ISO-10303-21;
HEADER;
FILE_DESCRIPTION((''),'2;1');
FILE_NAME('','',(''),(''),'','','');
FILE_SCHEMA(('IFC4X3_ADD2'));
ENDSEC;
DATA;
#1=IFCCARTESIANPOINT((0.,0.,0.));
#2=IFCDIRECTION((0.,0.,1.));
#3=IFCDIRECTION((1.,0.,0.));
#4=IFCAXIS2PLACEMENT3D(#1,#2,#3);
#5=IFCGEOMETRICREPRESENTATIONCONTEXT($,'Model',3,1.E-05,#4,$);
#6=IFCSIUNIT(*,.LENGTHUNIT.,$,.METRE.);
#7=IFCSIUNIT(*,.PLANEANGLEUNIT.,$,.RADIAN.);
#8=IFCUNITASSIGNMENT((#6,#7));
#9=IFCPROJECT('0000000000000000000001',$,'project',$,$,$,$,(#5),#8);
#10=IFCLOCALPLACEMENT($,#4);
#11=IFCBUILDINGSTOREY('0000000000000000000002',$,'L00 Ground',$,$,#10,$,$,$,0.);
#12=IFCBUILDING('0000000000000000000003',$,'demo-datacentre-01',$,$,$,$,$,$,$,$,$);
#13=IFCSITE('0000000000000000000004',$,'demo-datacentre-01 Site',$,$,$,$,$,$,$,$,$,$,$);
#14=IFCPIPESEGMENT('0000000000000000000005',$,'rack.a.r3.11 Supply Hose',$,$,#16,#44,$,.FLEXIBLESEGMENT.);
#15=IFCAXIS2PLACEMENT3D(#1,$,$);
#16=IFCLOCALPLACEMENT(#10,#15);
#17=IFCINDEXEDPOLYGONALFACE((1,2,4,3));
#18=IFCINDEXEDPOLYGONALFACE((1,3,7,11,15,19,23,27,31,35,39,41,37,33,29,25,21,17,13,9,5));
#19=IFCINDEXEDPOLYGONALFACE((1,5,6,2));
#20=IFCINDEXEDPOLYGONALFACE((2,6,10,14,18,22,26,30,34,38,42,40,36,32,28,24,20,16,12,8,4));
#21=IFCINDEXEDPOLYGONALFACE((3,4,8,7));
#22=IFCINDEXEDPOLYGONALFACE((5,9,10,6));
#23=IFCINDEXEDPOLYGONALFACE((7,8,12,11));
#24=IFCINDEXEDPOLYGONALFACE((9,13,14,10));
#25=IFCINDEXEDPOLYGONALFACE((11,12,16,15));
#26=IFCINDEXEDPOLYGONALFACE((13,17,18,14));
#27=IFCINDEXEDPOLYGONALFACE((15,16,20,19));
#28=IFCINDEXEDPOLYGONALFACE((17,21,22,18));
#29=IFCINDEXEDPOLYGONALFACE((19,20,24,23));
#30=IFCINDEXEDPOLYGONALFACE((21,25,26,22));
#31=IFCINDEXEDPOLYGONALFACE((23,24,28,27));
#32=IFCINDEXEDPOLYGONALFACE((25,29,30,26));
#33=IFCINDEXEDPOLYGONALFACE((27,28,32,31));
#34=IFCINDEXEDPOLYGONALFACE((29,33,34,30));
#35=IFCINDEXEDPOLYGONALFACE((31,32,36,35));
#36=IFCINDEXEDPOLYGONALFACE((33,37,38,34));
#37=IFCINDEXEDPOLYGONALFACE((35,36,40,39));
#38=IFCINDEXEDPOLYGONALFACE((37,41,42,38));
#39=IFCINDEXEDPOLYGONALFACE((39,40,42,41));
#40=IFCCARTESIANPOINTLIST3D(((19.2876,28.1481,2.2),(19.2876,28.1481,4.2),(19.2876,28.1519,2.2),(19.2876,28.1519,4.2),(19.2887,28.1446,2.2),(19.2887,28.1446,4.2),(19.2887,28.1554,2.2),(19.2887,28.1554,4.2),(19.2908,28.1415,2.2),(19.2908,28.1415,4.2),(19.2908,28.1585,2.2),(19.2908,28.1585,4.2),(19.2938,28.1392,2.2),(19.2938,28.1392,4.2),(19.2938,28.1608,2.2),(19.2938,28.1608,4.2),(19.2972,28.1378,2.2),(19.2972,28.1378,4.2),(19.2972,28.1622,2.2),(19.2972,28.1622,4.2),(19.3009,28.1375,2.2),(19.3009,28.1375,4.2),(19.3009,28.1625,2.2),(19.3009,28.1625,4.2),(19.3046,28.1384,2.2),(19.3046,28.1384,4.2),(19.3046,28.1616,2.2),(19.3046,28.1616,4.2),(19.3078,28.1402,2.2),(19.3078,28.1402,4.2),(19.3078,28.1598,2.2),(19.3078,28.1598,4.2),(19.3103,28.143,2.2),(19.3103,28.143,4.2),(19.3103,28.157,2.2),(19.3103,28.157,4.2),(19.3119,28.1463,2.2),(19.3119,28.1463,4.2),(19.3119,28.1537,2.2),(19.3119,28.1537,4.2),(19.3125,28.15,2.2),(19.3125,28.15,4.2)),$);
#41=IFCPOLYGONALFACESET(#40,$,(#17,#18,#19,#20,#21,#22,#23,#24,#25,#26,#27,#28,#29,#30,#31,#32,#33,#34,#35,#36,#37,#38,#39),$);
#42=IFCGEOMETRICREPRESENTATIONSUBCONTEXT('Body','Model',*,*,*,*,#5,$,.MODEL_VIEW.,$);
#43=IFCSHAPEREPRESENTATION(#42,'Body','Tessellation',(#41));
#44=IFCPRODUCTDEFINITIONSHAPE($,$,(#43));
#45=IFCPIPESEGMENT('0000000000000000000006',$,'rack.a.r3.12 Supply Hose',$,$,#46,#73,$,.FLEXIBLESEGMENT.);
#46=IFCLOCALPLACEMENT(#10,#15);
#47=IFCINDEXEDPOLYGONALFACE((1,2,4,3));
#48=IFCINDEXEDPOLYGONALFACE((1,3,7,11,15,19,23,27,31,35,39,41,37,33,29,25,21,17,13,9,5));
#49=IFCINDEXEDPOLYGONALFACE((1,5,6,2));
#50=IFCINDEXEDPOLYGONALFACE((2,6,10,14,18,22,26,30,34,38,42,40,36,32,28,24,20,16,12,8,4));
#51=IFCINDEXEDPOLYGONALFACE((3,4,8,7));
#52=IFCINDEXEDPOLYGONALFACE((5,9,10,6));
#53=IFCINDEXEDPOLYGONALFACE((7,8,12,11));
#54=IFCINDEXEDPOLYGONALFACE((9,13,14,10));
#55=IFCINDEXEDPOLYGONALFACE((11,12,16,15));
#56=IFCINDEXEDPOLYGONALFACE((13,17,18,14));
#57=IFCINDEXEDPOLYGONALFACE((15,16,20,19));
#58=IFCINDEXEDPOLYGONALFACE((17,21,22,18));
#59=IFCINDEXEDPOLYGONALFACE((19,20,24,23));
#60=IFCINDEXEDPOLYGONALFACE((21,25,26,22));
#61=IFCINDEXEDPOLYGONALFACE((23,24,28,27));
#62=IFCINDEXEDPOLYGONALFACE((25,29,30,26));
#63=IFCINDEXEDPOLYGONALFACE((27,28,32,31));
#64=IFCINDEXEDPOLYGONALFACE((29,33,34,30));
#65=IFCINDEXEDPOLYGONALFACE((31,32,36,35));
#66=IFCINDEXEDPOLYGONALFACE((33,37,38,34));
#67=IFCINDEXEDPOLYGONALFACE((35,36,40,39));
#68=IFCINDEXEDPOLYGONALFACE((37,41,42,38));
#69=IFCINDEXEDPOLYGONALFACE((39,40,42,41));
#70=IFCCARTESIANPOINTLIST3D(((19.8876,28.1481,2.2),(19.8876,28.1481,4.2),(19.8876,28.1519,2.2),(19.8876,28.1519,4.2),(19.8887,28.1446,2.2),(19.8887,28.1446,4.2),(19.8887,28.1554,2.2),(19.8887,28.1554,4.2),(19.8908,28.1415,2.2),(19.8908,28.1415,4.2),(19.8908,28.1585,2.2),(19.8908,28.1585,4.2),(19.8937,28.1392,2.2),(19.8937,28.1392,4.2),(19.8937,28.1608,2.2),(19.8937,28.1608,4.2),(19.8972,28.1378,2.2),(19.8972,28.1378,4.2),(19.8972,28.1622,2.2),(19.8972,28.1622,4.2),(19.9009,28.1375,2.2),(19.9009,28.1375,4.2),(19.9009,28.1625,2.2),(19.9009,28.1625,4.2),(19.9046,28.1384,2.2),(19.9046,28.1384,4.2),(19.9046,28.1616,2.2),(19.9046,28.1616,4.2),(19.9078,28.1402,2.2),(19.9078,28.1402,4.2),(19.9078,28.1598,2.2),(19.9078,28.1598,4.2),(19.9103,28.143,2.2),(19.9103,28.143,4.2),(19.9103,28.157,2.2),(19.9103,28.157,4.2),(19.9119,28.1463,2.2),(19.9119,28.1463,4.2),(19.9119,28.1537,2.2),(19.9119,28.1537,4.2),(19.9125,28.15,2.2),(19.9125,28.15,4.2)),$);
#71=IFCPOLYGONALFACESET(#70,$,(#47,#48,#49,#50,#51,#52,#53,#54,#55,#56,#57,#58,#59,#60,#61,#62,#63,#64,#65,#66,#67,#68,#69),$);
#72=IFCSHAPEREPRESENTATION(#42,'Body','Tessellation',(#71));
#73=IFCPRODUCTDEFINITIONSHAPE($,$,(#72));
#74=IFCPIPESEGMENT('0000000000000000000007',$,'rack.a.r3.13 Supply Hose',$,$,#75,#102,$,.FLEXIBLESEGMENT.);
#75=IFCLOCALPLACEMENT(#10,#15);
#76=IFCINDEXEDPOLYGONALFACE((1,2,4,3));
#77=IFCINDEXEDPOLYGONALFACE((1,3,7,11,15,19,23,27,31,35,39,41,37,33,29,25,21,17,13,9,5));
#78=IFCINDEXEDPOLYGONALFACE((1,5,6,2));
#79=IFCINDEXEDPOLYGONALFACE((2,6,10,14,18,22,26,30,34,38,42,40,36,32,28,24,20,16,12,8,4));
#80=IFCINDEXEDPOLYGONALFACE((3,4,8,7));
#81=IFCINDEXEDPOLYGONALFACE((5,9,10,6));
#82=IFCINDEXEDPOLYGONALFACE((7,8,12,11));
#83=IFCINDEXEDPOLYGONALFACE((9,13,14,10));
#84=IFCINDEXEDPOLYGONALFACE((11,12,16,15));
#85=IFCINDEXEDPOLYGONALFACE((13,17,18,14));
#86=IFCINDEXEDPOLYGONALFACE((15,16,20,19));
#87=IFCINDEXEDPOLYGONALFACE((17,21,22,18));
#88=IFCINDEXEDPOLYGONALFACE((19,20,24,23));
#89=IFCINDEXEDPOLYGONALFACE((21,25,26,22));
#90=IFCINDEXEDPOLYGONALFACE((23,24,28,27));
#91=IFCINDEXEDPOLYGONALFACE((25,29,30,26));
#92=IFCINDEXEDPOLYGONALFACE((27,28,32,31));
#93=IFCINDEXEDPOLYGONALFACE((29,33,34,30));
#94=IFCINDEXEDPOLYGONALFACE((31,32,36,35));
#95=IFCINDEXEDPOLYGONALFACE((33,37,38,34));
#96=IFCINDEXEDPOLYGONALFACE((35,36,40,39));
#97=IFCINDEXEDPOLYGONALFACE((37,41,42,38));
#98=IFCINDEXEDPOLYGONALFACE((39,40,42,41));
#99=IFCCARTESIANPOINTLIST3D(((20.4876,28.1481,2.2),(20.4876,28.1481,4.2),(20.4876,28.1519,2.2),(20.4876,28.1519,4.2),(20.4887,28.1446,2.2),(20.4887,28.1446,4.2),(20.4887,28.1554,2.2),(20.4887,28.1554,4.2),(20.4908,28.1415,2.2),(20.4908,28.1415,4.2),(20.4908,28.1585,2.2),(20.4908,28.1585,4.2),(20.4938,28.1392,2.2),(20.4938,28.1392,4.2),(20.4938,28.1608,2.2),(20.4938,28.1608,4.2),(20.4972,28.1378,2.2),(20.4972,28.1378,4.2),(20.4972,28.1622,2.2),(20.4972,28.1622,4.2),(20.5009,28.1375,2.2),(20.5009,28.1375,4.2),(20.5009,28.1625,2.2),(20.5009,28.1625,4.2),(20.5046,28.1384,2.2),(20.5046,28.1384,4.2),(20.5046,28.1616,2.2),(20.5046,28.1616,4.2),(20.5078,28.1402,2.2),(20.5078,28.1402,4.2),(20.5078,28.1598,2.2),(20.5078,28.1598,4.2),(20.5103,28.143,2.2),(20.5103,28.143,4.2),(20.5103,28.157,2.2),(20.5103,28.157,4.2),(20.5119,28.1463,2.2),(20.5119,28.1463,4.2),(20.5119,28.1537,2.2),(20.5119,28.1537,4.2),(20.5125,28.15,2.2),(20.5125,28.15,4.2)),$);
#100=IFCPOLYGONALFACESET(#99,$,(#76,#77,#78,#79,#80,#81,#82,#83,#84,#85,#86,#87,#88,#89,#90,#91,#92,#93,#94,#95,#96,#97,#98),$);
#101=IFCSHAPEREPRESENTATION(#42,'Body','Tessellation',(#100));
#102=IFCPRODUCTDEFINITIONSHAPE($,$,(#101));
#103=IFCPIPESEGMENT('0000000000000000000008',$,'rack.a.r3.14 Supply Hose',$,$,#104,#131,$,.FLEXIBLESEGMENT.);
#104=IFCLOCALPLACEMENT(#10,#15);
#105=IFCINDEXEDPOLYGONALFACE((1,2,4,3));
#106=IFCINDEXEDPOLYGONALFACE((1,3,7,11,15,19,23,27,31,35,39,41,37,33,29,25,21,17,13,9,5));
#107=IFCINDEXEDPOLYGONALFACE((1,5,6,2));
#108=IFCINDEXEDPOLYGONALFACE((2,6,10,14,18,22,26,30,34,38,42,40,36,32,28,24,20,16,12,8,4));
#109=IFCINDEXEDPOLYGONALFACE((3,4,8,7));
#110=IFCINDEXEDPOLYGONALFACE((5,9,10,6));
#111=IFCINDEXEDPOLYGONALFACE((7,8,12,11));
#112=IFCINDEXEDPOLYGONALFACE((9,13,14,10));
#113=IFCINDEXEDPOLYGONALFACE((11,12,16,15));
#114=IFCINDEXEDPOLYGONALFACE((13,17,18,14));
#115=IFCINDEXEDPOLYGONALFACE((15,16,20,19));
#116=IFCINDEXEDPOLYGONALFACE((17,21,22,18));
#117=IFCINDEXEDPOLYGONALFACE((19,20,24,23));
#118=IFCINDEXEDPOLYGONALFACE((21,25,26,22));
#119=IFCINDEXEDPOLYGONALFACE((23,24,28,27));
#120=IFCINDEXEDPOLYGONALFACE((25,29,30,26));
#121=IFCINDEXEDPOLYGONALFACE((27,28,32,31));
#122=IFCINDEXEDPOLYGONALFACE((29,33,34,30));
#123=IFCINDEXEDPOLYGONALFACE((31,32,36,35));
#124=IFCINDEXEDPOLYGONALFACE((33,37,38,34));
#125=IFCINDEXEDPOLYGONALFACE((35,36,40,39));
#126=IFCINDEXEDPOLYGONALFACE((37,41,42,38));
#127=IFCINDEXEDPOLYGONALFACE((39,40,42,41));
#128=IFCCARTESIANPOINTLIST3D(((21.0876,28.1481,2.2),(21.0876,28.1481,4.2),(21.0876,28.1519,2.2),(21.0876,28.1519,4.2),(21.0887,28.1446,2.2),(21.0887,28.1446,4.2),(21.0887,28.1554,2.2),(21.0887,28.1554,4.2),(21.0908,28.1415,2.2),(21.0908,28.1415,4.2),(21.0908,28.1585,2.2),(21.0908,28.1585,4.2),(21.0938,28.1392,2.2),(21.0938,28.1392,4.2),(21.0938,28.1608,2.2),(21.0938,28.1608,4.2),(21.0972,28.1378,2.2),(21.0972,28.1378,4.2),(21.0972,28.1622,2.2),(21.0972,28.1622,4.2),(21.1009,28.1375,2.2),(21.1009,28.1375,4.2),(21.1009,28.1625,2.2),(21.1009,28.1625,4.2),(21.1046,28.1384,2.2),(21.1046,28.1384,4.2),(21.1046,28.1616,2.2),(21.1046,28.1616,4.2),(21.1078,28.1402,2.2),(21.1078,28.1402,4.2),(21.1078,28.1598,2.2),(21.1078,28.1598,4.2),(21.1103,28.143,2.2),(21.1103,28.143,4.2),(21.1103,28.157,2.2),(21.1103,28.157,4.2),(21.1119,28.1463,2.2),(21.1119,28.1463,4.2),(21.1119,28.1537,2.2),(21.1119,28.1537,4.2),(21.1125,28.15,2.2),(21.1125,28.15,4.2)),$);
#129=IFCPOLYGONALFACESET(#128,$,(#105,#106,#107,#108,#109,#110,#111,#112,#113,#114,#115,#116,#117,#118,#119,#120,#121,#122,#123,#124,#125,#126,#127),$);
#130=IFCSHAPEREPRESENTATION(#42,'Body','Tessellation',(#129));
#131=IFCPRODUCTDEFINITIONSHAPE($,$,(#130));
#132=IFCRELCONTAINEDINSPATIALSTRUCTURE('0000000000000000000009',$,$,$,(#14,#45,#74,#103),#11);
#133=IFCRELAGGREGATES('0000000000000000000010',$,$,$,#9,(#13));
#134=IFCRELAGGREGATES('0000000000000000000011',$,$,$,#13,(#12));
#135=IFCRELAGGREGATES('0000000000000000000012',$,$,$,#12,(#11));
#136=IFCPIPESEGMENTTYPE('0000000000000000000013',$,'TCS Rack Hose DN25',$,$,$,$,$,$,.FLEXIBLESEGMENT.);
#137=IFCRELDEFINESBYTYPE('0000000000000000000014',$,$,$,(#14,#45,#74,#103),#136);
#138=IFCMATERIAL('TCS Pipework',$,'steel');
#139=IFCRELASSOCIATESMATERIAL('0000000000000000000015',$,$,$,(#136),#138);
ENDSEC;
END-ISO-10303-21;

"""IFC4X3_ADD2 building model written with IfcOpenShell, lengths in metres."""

from ifc_helpers import new_model, si_unit, frame, origin_with_axes, place, context, subcontext, project, spatial, circle, extrude, material, type_object, element, save


model = new_model("IFC4X3_ADD2")

# Units and contexts
model_context = context("Model", 3, precision=1e-05, world=origin_with_axes())
body_context = subcontext(model_context, "Body", "Model", "MODEL_VIEW")
ifc_project = project(units=[si_unit("LENGTHUNIT", "METRE"), si_unit("PLANEANGLEUNIT", "RADIAN")], contexts=[model_context])

# Site, building, storey
site = spatial("IfcSite", under=ifc_project, Name="demo-datacentre-01 Site")
building = spatial("IfcBuilding", under=site, Name="demo-datacentre-01")
storey_placement = place(None, origin_with_axes())
storey = spatial("IfcBuildingStorey", under=building, at=storey_placement, Name="L00 Ground", Elevation=0.0)

# Shared definitions
ifc_material = material(Name="TCS Pipework", Category="steel")

# Pipe segments
pipe_segment_type_1 = type_object("IfcPipeSegmentType", Name="TCS Rack Hose DN25", PredefinedType="FLEXIBLESEGMENT", material=ifc_material)
for number, where, z_axis, x_axis, name in (
    (1, (19.3, 28.15, 4.2), (0.0, 0.0, -1.0), (1.0, 0.0, 0.0), "rack.a.r3.11 Supply Hose"),
    (2, (19.9, 28.15, 4.2), (0.0, 0.0, -1.0), (1.0, 0.0, 0.0), "rack.a.r3.12 Supply Hose"),
    (3, (20.5, 28.15, 4.2), (0.0, 0.0, -1.0), (1.0, 0.0, 0.0), "rack.a.r3.13 Supply Hose"),
    (4, (21.1, 28.15, 4.2), (0.0, 0.0, -1.0), (1.0, 0.0, 0.0), "rack.a.r3.14 Supply Hose"),
):
    element("IfcPipeSegment", number, at=place(storey_placement, frame(where, z_axis=z_axis, x_axis=x_axis)), inside=storey, type_object=pipe_segment_type_1, Name=name, PredefinedType="FLEXIBLESEGMENT", context=body_context, shape_type="SweptSolid", body=[
        extrude(circle(Radius=0.0125), origin_with_axes(), (0.0, 0.0, 1.0), 2.0),
    ])

save(model, "model.ifc")
